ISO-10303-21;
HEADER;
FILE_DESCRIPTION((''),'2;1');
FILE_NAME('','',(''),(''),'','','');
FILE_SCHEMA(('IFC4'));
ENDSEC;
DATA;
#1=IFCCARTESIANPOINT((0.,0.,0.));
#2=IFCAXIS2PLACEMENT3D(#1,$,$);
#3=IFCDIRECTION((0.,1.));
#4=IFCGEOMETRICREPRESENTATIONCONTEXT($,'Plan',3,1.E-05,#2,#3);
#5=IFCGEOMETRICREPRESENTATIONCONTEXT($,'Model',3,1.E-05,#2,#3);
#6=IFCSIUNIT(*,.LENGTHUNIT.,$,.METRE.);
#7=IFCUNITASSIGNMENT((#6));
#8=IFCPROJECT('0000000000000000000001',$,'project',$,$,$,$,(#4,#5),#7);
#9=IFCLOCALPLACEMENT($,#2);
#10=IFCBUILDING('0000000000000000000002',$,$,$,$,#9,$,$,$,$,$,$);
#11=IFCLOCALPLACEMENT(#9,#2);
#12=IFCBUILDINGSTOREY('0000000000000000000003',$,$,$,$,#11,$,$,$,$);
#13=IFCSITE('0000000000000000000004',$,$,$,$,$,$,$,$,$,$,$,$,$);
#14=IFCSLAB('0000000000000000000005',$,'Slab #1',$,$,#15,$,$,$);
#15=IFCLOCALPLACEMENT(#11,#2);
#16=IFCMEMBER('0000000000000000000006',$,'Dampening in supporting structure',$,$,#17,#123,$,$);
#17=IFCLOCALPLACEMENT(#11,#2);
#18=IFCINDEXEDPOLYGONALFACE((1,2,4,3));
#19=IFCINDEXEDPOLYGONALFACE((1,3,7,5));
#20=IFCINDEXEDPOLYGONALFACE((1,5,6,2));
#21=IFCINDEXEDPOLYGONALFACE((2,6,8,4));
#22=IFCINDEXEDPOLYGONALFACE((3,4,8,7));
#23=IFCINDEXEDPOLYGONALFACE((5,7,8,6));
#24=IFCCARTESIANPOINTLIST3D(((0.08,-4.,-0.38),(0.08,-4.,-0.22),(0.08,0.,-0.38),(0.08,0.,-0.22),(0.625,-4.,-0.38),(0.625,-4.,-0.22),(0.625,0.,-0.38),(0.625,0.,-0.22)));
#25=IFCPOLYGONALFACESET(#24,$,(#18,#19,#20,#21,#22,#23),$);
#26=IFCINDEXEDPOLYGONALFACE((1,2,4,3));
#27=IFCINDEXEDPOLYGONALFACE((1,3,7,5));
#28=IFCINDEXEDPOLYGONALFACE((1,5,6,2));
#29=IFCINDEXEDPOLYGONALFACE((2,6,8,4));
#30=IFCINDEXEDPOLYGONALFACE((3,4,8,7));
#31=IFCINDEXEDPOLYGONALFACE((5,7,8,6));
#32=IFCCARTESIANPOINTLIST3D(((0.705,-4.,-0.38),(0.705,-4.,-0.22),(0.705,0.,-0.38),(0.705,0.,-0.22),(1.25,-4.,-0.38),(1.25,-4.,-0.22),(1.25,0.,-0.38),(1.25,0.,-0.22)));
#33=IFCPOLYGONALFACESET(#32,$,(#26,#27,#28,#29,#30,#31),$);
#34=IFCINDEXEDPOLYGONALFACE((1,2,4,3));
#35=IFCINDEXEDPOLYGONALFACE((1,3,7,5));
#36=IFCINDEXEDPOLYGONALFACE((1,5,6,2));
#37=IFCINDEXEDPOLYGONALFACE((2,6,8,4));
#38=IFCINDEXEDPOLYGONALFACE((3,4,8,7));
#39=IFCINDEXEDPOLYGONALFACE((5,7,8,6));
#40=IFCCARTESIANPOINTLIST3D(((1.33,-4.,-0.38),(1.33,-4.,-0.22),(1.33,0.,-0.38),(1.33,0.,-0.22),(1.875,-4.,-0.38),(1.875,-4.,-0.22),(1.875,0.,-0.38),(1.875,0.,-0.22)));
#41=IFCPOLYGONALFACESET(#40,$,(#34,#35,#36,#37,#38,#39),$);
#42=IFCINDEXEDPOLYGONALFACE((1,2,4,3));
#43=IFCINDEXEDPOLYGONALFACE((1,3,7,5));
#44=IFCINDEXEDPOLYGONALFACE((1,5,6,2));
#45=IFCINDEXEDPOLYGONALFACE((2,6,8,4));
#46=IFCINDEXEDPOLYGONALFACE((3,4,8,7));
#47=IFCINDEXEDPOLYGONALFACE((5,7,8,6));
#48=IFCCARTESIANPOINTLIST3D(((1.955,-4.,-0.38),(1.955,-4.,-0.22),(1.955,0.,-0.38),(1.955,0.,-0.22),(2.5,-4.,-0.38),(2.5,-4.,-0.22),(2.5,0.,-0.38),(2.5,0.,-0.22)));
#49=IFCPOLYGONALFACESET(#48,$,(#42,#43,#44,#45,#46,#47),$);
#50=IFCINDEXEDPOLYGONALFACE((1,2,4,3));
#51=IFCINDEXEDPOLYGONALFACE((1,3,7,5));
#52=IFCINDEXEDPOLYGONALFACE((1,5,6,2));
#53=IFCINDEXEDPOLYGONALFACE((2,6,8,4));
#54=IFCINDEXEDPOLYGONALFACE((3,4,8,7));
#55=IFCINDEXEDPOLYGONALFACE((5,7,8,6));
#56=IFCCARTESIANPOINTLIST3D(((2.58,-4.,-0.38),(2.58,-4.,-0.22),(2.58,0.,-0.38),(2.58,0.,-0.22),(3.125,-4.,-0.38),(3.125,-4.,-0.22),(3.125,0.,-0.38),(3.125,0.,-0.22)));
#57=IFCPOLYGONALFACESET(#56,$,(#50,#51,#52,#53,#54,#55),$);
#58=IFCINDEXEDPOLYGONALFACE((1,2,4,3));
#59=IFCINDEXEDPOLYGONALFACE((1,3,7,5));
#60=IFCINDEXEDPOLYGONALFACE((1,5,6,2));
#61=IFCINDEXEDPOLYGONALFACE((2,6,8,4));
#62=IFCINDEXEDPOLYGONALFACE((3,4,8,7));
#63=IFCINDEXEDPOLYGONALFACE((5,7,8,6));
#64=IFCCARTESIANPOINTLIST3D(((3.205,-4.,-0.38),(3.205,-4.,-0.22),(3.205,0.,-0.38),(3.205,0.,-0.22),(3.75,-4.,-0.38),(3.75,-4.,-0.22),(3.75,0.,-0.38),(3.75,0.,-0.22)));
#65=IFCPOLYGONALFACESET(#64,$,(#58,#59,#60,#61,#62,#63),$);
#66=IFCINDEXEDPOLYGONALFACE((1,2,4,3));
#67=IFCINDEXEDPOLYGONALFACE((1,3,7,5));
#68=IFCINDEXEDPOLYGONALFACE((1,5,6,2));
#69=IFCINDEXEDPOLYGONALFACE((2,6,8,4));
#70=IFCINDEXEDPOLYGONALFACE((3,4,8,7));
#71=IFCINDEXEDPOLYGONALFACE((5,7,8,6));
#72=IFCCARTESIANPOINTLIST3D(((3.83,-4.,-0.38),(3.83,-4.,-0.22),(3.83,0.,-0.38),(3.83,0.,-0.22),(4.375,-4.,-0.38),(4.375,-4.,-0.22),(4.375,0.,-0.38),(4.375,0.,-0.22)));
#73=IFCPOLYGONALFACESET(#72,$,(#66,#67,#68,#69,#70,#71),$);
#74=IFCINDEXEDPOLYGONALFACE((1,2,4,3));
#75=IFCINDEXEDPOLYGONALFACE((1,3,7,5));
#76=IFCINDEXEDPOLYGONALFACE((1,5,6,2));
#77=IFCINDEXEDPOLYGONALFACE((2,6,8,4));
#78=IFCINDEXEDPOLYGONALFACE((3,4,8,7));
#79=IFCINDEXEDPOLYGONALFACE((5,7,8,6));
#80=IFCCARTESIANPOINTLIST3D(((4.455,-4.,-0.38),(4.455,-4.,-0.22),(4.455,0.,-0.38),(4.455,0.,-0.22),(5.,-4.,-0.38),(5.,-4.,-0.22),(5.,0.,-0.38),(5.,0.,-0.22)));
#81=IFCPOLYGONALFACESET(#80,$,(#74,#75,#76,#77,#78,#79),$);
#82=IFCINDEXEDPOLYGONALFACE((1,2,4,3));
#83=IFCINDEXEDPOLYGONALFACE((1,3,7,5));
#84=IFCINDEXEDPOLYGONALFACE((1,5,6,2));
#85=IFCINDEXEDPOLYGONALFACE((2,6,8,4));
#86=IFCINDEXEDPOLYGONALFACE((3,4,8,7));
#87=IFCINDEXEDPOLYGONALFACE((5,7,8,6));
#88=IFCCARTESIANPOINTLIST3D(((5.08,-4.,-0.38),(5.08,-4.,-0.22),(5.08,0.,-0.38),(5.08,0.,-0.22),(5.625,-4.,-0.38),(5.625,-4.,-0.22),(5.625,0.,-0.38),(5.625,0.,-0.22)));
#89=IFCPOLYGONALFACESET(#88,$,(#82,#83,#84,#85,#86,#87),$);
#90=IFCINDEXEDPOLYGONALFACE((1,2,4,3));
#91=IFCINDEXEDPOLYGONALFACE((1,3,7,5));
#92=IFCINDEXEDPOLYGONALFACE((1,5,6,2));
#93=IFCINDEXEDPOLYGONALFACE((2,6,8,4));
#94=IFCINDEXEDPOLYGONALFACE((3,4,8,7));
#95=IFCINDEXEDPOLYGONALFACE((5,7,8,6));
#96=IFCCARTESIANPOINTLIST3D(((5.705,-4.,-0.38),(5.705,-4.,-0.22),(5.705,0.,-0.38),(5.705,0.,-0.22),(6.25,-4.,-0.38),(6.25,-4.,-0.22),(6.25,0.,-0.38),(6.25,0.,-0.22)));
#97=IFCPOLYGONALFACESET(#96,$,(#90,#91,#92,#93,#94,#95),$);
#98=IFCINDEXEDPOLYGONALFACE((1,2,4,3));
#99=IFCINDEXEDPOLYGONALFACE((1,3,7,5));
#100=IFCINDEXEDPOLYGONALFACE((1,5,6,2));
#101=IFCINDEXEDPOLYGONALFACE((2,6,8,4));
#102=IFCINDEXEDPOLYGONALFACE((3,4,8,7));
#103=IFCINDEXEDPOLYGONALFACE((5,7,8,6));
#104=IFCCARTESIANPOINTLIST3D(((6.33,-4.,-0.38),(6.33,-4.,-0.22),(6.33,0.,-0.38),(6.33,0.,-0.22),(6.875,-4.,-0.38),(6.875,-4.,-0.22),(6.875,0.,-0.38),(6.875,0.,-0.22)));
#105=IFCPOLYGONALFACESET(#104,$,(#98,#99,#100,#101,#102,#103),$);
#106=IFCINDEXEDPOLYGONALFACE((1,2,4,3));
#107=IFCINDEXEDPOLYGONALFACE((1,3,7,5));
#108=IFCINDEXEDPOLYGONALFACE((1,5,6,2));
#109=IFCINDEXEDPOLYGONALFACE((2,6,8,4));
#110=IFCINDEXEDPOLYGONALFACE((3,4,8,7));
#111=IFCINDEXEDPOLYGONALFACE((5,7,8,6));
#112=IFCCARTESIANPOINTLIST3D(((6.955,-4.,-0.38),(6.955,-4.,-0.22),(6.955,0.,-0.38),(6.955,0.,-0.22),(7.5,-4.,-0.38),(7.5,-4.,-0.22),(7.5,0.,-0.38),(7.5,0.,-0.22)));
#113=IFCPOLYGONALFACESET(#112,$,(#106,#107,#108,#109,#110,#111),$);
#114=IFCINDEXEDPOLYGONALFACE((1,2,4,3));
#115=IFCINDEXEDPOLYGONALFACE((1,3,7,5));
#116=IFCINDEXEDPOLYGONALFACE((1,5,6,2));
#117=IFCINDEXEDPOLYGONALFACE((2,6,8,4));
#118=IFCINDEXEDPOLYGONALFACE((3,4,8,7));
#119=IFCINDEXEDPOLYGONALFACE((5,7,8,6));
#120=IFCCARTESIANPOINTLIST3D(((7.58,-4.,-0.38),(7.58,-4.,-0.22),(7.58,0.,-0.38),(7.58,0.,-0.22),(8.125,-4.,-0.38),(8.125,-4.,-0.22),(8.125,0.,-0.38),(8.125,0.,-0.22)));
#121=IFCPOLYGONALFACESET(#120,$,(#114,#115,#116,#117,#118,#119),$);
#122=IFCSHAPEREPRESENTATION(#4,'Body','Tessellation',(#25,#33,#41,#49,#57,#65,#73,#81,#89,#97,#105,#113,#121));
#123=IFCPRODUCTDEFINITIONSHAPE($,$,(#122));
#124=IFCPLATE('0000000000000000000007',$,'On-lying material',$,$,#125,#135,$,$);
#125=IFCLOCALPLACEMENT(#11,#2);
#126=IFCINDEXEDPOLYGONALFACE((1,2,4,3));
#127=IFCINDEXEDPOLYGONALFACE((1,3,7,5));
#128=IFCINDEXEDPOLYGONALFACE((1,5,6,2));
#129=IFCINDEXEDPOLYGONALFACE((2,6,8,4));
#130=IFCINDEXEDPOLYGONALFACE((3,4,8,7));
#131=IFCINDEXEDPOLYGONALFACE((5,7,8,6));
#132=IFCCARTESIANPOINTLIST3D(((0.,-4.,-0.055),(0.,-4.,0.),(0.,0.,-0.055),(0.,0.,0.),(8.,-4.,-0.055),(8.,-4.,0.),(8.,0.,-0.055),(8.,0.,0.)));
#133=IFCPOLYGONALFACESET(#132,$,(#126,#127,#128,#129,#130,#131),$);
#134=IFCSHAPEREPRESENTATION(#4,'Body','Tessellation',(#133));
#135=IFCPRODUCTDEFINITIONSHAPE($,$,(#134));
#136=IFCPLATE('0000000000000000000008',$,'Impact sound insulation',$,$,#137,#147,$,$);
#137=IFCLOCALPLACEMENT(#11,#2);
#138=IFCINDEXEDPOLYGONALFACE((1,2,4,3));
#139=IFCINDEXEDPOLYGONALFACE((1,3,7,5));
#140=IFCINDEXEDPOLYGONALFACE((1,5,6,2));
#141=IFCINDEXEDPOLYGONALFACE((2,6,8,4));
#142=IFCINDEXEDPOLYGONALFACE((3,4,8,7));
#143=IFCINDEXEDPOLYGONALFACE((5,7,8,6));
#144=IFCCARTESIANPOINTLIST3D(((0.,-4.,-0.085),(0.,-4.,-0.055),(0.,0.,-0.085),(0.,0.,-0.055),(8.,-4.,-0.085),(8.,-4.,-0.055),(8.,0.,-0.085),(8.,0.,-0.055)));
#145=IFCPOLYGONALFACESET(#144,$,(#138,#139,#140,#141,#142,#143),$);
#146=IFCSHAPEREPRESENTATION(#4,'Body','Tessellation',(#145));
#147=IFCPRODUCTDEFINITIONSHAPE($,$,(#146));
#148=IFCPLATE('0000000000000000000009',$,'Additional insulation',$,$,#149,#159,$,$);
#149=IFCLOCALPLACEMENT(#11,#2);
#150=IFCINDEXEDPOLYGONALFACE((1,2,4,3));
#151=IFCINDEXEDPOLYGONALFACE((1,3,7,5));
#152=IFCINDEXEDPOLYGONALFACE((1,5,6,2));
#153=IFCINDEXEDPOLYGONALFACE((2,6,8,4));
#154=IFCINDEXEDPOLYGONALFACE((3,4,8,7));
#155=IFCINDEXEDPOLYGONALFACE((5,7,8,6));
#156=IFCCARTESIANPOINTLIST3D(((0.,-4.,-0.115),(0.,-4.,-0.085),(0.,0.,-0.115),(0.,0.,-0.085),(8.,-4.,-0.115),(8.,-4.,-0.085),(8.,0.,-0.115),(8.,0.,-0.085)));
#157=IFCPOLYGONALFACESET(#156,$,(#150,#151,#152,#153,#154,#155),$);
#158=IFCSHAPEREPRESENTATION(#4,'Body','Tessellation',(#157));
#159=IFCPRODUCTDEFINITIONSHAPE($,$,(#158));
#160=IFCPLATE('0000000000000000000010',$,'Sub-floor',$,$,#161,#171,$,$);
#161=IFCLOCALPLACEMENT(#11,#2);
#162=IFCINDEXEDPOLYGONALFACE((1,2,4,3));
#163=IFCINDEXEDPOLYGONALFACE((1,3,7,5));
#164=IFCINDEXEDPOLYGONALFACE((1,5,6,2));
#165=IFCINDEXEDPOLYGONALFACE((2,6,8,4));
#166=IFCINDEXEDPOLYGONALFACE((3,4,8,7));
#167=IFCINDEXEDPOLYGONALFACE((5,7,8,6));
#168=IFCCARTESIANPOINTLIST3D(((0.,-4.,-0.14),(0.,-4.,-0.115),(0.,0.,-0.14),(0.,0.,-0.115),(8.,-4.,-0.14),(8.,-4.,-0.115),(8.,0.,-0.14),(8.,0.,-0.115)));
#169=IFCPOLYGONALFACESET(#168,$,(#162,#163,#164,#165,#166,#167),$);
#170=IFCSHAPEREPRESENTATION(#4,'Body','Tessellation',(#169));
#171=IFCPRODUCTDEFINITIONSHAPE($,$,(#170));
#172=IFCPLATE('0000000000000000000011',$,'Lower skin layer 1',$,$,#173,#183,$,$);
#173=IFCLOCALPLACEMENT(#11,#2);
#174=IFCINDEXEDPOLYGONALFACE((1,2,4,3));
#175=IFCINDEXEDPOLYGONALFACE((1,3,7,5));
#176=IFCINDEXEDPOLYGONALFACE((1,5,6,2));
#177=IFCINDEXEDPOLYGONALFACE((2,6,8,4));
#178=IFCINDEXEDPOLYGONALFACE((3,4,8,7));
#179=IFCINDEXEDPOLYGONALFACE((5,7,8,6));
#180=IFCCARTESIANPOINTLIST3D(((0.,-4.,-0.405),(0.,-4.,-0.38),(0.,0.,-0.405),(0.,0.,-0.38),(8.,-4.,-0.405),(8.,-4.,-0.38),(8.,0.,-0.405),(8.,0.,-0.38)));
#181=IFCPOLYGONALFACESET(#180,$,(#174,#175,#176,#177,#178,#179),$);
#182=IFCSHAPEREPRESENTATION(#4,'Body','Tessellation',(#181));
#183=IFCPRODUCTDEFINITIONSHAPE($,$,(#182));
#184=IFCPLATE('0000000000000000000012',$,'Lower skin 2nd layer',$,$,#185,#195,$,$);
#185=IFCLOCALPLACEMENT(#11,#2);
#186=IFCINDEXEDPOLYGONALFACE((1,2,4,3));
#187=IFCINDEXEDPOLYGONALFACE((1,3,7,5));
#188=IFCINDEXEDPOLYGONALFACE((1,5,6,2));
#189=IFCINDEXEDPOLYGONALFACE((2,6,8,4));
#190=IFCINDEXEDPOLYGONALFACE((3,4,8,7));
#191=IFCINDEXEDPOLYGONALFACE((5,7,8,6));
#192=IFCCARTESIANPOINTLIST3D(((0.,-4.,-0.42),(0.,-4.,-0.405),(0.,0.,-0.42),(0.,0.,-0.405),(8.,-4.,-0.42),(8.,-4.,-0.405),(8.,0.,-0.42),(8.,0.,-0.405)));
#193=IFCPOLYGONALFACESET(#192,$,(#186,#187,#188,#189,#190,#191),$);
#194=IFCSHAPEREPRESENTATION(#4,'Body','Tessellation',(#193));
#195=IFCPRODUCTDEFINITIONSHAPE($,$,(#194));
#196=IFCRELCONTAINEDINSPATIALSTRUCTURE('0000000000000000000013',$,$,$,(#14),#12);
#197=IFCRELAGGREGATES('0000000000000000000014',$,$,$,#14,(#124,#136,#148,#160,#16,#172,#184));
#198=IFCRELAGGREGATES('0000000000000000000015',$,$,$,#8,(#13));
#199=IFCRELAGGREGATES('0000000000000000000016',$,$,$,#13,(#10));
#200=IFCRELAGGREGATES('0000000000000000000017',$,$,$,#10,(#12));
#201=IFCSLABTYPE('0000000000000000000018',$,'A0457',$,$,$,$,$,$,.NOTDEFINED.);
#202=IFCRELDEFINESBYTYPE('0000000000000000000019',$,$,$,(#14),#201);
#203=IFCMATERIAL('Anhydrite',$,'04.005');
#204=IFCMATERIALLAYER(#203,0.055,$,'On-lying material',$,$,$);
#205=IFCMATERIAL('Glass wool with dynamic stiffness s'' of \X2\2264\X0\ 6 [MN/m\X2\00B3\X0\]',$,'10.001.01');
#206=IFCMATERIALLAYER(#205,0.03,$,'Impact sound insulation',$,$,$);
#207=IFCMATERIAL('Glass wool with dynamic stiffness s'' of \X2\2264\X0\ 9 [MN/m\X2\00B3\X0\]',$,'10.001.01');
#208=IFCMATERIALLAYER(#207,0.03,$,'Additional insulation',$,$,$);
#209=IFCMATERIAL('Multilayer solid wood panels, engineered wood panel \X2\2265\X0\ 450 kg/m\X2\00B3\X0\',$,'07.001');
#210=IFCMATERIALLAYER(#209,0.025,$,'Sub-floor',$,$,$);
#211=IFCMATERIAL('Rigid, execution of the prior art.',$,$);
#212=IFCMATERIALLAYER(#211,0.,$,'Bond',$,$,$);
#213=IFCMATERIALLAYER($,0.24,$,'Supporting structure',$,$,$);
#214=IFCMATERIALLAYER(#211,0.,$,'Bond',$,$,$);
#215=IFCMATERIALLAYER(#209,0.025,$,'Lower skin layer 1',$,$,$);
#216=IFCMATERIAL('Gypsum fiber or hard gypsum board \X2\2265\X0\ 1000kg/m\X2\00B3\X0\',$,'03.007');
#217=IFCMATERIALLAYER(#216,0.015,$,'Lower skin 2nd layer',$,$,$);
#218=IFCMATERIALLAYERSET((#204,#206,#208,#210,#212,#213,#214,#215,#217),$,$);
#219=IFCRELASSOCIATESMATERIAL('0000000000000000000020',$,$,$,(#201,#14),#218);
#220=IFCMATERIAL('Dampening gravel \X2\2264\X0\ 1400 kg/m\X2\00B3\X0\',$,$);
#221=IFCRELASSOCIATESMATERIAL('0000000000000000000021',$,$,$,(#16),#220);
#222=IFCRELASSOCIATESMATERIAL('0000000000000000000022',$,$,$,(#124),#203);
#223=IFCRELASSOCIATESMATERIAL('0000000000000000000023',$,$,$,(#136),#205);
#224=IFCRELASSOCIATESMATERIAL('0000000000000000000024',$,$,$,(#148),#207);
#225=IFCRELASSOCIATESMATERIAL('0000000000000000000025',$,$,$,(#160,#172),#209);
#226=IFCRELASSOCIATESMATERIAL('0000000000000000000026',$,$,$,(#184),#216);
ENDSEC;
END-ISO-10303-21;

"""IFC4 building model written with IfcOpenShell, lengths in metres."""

from ifc_helpers import new_model, si_unit, direction, frame, frame_2d, origin, origin_with_axes, place, context, project, spatial, rectangle, extrude, material, layer, layer_set, type_object, element, aggregate, save


model = new_model("IFC4")

# Units and contexts
plan_context = context("Plan", 3, precision=1e-05, world=origin(), true_north=direction((0.0, 1.0)))
model_context = context("Model", 3, precision=1e-05, world=origin(), true_north=direction((0.0, 1.0)))
ifc_project = project(units=[si_unit("LENGTHUNIT", "METRE")], contexts=[plan_context, model_context])

# Site, building, storey
site = spatial("IfcSite", under=ifc_project)
building_placement = place(None, origin())
building = spatial("IfcBuilding", under=site, at=building_placement)
storey_placement = place(building_placement, origin())
storey = spatial("IfcBuildingStorey", under=building, at=storey_placement)

# Slab, member, plates
ifc_material_1 = material(Name="Anhydrite", Category="04.005")
ifc_layer_1 = layer(ifc_material_1, 0.055, Name="On-lying material")
ifc_material_2 = material(Name="Glass wool with dynamic stiffness s' of ≤ 6 [MN/m³]", Category="10.001.01")
ifc_layer_2 = layer(ifc_material_2, 0.03, Name="Impact sound insulation")
ifc_material_3 = material(Name="Glass wool with dynamic stiffness s' of ≤ 9 [MN/m³]", Category="10.001.01")
ifc_layer_3 = layer(ifc_material_3, 0.03, Name="Additional insulation")
ifc_material_4 = material(Name="Multilayer solid wood panels, engineered wood panel ≥ 450 kg/m³", Category="07.001")
ifc_layer_4 = layer(ifc_material_4, 0.025, Name="Sub-floor")
ifc_material_5 = material(Name="Rigid, execution of the prior art.")
ifc_layer_5 = layer(ifc_material_5, 0.0, Name="Bond")
ifc_layer_6 = layer(None, 0.24, Name="Supporting structure")
ifc_layer_7 = layer(ifc_material_5, 0.0, Name="Bond")
ifc_layer_8 = layer(ifc_material_4, 0.025, Name="Lower skin layer 1")
ifc_material_6 = material(Name="Gypsum fiber or hard gypsum board ≥ 1000kg/m³", Category="03.007")
ifc_layer_9 = layer(ifc_material_6, 0.015, Name="Lower skin 2nd layer")
ifc_layer_set = layer_set([ifc_layer_1, ifc_layer_2, ifc_layer_3, ifc_layer_4, ifc_layer_5, ifc_layer_6, ifc_layer_7, ifc_layer_8, ifc_layer_9])
slab_type = type_object("IfcSlabType", Name="A0457", PredefinedType="NOTDEFINED", material=ifc_layer_set)
slab_placement = place(None, frame((0.0, 0.0, 0.0), z_axis=(0.0, 0.0, -1.0), x_axis=(1.0, 0.0, 0.0)))
slab = element("IfcSlab", 1, at=slab_placement, inside=storey, type_object=slab_type, material=ifc_layer_set, Name="Slab #1")
ifc_material_7 = material(Name="Dampening gravel ≤ 1400 kg/m³")
member_1_placement = place(slab_placement, origin())
member_1 = element("IfcMember", 2, at=member_1_placement, material=ifc_material_7, Name="Dampening in supporting structure", context=plan_context, shape_type="SweptSolid", body=[
    extrude(rectangle(XDim=0.545, YDim=0.16, at=frame_2d((0.2725, 0.08), x_axis=(1.0, 0.0))), frame((0.08, 4.0, 0.22), z_axis=(0.0, -1.0, 0.0), x_axis=(1.0, 0.0, 0.0)), (0.0, 0.0, 1.0), 4.0),
    extrude(rectangle(XDim=0.545, YDim=0.16, at=frame_2d((0.2725, 0.08), x_axis=(1.0, 0.0))), frame((0.705, 4.0, 0.22), z_axis=(0.0, -1.0, 0.0), x_axis=(1.0, 0.0, 0.0)), (0.0, 0.0, 1.0), 4.0),
    extrude(rectangle(XDim=0.545, YDim=0.16, at=frame_2d((0.2725, 0.08), x_axis=(1.0, 0.0))), frame((1.33, 4.0, 0.22), z_axis=(0.0, -1.0, 0.0), x_axis=(1.0, 0.0, 0.0)), (0.0, 0.0, 1.0), 4.0),
    extrude(rectangle(XDim=0.545, YDim=0.16, at=frame_2d((0.2725, 0.08), x_axis=(1.0, 0.0))), frame((1.955, 4.0, 0.22), z_axis=(0.0, -1.0, 0.0), x_axis=(1.0, 0.0, 0.0)), (0.0, 0.0, 1.0), 4.0),
    extrude(rectangle(XDim=0.545, YDim=0.16, at=frame_2d((0.2725, 0.08), x_axis=(1.0, 0.0))), frame((2.58, 4.0, 0.22), z_axis=(0.0, -1.0, 0.0), x_axis=(1.0, 0.0, 0.0)), (0.0, 0.0, 1.0), 4.0),
    extrude(rectangle(XDim=0.545, YDim=0.16, at=frame_2d((0.2725, 0.08), x_axis=(1.0, 0.0))), frame((3.205, 4.0, 0.22), z_axis=(0.0, -1.0, 0.0), x_axis=(1.0, 0.0, 0.0)), (0.0, 0.0, 1.0), 4.0),
    extrude(rectangle(XDim=0.545, YDim=0.16, at=frame_2d((0.2725, 0.08), x_axis=(1.0, 0.0))), frame((3.83, 4.0, 0.22), z_axis=(0.0, -1.0, 0.0), x_axis=(1.0, 0.0, 0.0)), (0.0, 0.0, 1.0), 4.0),
    extrude(rectangle(XDim=0.545, YDim=0.16, at=frame_2d((0.2725, 0.08), x_axis=(1.0, 0.0))), frame((4.455, 4.0, 0.22), z_axis=(0.0, -1.0, 0.0), x_axis=(1.0, 0.0, 0.0)), (0.0, 0.0, 1.0), 4.0),
    extrude(rectangle(XDim=0.545, YDim=0.16, at=frame_2d((0.2725, 0.08), x_axis=(1.0, 0.0))), frame((5.08, 4.0, 0.22), z_axis=(0.0, -1.0, 0.0), x_axis=(1.0, 0.0, 0.0)), (0.0, 0.0, 1.0), 4.0),
    extrude(rectangle(XDim=0.545, YDim=0.16, at=frame_2d((0.2725, 0.08), x_axis=(1.0, 0.0))), frame((5.705, 4.0, 0.22), z_axis=(0.0, -1.0, 0.0), x_axis=(1.0, 0.0, 0.0)), (0.0, 0.0, 1.0), 4.0),
    extrude(rectangle(XDim=0.545, YDim=0.16, at=frame_2d((0.2725, 0.08), x_axis=(1.0, 0.0))), frame((6.33, 4.0, 0.22), z_axis=(0.0, -1.0, 0.0), x_axis=(1.0, 0.0, 0.0)), (0.0, 0.0, 1.0), 4.0),
    extrude(rectangle(XDim=0.545, YDim=0.16, at=frame_2d((0.2725, 0.08), x_axis=(1.0, 0.0))), frame((6.955, 4.0, 0.22), z_axis=(0.0, -1.0, 0.0), x_axis=(1.0, 0.0, 0.0)), (0.0, 0.0, 1.0), 4.0),
    extrude(rectangle(XDim=0.545, YDim=0.16, at=frame_2d((0.2725, 0.08), x_axis=(1.0, 0.0))), frame((7.58, 4.0, 0.22), z_axis=(0.0, -1.0, 0.0), x_axis=(1.0, 0.0, 0.0)), (0.0, 0.0, 1.0), 4.0),
])
plate_1_placement = place(slab_placement, origin())
plate_1 = element("IfcPlate", 3, at=plate_1_placement, material=ifc_material_1, Name="On-lying material", context=plan_context, shape_type="SweptSolid", body=[
    extrude(rectangle(XDim=8.0, YDim=4.0, at=frame_2d((4.0, 2.0), x_axis=(1.0, 0.0))), origin_with_axes(), (0.0, 0.0, 1.0), 0.055),
])
plate_2_placement = place(slab_placement, origin())
plate_2 = element("IfcPlate", 4, at=plate_2_placement, material=ifc_material_2, Name="Impact sound insulation", context=plan_context, shape_type="SweptSolid", body=[
    extrude(rectangle(XDim=8.0, YDim=4.0, at=frame_2d((4.0, 2.0), x_axis=(1.0, 0.0))), frame((0.0, 0.0, 0.055), z_axis=(0.0, 0.0, 1.0), x_axis=(1.0, 0.0, 0.0)), (0.0, 0.0, 1.0), 0.03),
])
plate_3_placement = place(slab_placement, origin())
plate_3 = element("IfcPlate", 5, at=plate_3_placement, material=ifc_material_3, Name="Additional insulation", context=plan_context, shape_type="SweptSolid", body=[
    extrude(rectangle(XDim=8.0, YDim=4.0, at=frame_2d((4.0, 2.0), x_axis=(1.0, 0.0))), frame((0.0, 0.0, 0.085), z_axis=(0.0, 0.0, 1.0), x_axis=(1.0, 0.0, 0.0)), (0.0, 0.0, 1.0), 0.03),
])
plate_4_placement = place(slab_placement, origin())
plate_4 = element("IfcPlate", 6, at=plate_4_placement, material=ifc_material_4, Name="Sub-floor", context=plan_context, shape_type="SweptSolid", body=[
    extrude(rectangle(XDim=8.0, YDim=4.0, at=frame_2d((4.0, 2.0), x_axis=(1.0, 0.0))), frame((0.0, 0.0, 0.115), z_axis=(0.0, 0.0, 1.0), x_axis=(1.0, 0.0, 0.0)), (0.0, 0.0, 1.0), 0.025),
])
plate_5_placement = place(slab_placement, origin())
plate_5 = element("IfcPlate", 7, at=plate_5_placement, material=ifc_material_4, Name="Lower skin layer 1", context=plan_context, shape_type="SweptSolid", body=[
    extrude(rectangle(XDim=8.0, YDim=4.0, at=frame_2d((4.0, 2.0), x_axis=(1.0, 0.0))), frame((0.0, 0.0, 0.38), z_axis=(0.0, 0.0, 1.0), x_axis=(1.0, 0.0, 0.0)), (0.0, 0.0, 1.0), 0.025),
])
plate_6_placement = place(slab_placement, origin())
plate_6 = element("IfcPlate", 8, at=plate_6_placement, material=ifc_material_6, Name="Lower skin 2nd layer", context=plan_context, shape_type="SweptSolid", body=[
    extrude(rectangle(XDim=8.0, YDim=4.0, at=frame_2d((4.0, 2.0), x_axis=(1.0, 0.0))), frame((0.0, 0.0, 0.405), z_axis=(0.0, 0.0, 1.0), x_axis=(1.0, 0.0, 0.0)), (0.0, 0.0, 1.0), 0.015),
])
aggregate(slab, [plate_1, plate_2, plate_3, plate_4, member_1, plate_5, plate_6])

save(model, "model.ifc")
